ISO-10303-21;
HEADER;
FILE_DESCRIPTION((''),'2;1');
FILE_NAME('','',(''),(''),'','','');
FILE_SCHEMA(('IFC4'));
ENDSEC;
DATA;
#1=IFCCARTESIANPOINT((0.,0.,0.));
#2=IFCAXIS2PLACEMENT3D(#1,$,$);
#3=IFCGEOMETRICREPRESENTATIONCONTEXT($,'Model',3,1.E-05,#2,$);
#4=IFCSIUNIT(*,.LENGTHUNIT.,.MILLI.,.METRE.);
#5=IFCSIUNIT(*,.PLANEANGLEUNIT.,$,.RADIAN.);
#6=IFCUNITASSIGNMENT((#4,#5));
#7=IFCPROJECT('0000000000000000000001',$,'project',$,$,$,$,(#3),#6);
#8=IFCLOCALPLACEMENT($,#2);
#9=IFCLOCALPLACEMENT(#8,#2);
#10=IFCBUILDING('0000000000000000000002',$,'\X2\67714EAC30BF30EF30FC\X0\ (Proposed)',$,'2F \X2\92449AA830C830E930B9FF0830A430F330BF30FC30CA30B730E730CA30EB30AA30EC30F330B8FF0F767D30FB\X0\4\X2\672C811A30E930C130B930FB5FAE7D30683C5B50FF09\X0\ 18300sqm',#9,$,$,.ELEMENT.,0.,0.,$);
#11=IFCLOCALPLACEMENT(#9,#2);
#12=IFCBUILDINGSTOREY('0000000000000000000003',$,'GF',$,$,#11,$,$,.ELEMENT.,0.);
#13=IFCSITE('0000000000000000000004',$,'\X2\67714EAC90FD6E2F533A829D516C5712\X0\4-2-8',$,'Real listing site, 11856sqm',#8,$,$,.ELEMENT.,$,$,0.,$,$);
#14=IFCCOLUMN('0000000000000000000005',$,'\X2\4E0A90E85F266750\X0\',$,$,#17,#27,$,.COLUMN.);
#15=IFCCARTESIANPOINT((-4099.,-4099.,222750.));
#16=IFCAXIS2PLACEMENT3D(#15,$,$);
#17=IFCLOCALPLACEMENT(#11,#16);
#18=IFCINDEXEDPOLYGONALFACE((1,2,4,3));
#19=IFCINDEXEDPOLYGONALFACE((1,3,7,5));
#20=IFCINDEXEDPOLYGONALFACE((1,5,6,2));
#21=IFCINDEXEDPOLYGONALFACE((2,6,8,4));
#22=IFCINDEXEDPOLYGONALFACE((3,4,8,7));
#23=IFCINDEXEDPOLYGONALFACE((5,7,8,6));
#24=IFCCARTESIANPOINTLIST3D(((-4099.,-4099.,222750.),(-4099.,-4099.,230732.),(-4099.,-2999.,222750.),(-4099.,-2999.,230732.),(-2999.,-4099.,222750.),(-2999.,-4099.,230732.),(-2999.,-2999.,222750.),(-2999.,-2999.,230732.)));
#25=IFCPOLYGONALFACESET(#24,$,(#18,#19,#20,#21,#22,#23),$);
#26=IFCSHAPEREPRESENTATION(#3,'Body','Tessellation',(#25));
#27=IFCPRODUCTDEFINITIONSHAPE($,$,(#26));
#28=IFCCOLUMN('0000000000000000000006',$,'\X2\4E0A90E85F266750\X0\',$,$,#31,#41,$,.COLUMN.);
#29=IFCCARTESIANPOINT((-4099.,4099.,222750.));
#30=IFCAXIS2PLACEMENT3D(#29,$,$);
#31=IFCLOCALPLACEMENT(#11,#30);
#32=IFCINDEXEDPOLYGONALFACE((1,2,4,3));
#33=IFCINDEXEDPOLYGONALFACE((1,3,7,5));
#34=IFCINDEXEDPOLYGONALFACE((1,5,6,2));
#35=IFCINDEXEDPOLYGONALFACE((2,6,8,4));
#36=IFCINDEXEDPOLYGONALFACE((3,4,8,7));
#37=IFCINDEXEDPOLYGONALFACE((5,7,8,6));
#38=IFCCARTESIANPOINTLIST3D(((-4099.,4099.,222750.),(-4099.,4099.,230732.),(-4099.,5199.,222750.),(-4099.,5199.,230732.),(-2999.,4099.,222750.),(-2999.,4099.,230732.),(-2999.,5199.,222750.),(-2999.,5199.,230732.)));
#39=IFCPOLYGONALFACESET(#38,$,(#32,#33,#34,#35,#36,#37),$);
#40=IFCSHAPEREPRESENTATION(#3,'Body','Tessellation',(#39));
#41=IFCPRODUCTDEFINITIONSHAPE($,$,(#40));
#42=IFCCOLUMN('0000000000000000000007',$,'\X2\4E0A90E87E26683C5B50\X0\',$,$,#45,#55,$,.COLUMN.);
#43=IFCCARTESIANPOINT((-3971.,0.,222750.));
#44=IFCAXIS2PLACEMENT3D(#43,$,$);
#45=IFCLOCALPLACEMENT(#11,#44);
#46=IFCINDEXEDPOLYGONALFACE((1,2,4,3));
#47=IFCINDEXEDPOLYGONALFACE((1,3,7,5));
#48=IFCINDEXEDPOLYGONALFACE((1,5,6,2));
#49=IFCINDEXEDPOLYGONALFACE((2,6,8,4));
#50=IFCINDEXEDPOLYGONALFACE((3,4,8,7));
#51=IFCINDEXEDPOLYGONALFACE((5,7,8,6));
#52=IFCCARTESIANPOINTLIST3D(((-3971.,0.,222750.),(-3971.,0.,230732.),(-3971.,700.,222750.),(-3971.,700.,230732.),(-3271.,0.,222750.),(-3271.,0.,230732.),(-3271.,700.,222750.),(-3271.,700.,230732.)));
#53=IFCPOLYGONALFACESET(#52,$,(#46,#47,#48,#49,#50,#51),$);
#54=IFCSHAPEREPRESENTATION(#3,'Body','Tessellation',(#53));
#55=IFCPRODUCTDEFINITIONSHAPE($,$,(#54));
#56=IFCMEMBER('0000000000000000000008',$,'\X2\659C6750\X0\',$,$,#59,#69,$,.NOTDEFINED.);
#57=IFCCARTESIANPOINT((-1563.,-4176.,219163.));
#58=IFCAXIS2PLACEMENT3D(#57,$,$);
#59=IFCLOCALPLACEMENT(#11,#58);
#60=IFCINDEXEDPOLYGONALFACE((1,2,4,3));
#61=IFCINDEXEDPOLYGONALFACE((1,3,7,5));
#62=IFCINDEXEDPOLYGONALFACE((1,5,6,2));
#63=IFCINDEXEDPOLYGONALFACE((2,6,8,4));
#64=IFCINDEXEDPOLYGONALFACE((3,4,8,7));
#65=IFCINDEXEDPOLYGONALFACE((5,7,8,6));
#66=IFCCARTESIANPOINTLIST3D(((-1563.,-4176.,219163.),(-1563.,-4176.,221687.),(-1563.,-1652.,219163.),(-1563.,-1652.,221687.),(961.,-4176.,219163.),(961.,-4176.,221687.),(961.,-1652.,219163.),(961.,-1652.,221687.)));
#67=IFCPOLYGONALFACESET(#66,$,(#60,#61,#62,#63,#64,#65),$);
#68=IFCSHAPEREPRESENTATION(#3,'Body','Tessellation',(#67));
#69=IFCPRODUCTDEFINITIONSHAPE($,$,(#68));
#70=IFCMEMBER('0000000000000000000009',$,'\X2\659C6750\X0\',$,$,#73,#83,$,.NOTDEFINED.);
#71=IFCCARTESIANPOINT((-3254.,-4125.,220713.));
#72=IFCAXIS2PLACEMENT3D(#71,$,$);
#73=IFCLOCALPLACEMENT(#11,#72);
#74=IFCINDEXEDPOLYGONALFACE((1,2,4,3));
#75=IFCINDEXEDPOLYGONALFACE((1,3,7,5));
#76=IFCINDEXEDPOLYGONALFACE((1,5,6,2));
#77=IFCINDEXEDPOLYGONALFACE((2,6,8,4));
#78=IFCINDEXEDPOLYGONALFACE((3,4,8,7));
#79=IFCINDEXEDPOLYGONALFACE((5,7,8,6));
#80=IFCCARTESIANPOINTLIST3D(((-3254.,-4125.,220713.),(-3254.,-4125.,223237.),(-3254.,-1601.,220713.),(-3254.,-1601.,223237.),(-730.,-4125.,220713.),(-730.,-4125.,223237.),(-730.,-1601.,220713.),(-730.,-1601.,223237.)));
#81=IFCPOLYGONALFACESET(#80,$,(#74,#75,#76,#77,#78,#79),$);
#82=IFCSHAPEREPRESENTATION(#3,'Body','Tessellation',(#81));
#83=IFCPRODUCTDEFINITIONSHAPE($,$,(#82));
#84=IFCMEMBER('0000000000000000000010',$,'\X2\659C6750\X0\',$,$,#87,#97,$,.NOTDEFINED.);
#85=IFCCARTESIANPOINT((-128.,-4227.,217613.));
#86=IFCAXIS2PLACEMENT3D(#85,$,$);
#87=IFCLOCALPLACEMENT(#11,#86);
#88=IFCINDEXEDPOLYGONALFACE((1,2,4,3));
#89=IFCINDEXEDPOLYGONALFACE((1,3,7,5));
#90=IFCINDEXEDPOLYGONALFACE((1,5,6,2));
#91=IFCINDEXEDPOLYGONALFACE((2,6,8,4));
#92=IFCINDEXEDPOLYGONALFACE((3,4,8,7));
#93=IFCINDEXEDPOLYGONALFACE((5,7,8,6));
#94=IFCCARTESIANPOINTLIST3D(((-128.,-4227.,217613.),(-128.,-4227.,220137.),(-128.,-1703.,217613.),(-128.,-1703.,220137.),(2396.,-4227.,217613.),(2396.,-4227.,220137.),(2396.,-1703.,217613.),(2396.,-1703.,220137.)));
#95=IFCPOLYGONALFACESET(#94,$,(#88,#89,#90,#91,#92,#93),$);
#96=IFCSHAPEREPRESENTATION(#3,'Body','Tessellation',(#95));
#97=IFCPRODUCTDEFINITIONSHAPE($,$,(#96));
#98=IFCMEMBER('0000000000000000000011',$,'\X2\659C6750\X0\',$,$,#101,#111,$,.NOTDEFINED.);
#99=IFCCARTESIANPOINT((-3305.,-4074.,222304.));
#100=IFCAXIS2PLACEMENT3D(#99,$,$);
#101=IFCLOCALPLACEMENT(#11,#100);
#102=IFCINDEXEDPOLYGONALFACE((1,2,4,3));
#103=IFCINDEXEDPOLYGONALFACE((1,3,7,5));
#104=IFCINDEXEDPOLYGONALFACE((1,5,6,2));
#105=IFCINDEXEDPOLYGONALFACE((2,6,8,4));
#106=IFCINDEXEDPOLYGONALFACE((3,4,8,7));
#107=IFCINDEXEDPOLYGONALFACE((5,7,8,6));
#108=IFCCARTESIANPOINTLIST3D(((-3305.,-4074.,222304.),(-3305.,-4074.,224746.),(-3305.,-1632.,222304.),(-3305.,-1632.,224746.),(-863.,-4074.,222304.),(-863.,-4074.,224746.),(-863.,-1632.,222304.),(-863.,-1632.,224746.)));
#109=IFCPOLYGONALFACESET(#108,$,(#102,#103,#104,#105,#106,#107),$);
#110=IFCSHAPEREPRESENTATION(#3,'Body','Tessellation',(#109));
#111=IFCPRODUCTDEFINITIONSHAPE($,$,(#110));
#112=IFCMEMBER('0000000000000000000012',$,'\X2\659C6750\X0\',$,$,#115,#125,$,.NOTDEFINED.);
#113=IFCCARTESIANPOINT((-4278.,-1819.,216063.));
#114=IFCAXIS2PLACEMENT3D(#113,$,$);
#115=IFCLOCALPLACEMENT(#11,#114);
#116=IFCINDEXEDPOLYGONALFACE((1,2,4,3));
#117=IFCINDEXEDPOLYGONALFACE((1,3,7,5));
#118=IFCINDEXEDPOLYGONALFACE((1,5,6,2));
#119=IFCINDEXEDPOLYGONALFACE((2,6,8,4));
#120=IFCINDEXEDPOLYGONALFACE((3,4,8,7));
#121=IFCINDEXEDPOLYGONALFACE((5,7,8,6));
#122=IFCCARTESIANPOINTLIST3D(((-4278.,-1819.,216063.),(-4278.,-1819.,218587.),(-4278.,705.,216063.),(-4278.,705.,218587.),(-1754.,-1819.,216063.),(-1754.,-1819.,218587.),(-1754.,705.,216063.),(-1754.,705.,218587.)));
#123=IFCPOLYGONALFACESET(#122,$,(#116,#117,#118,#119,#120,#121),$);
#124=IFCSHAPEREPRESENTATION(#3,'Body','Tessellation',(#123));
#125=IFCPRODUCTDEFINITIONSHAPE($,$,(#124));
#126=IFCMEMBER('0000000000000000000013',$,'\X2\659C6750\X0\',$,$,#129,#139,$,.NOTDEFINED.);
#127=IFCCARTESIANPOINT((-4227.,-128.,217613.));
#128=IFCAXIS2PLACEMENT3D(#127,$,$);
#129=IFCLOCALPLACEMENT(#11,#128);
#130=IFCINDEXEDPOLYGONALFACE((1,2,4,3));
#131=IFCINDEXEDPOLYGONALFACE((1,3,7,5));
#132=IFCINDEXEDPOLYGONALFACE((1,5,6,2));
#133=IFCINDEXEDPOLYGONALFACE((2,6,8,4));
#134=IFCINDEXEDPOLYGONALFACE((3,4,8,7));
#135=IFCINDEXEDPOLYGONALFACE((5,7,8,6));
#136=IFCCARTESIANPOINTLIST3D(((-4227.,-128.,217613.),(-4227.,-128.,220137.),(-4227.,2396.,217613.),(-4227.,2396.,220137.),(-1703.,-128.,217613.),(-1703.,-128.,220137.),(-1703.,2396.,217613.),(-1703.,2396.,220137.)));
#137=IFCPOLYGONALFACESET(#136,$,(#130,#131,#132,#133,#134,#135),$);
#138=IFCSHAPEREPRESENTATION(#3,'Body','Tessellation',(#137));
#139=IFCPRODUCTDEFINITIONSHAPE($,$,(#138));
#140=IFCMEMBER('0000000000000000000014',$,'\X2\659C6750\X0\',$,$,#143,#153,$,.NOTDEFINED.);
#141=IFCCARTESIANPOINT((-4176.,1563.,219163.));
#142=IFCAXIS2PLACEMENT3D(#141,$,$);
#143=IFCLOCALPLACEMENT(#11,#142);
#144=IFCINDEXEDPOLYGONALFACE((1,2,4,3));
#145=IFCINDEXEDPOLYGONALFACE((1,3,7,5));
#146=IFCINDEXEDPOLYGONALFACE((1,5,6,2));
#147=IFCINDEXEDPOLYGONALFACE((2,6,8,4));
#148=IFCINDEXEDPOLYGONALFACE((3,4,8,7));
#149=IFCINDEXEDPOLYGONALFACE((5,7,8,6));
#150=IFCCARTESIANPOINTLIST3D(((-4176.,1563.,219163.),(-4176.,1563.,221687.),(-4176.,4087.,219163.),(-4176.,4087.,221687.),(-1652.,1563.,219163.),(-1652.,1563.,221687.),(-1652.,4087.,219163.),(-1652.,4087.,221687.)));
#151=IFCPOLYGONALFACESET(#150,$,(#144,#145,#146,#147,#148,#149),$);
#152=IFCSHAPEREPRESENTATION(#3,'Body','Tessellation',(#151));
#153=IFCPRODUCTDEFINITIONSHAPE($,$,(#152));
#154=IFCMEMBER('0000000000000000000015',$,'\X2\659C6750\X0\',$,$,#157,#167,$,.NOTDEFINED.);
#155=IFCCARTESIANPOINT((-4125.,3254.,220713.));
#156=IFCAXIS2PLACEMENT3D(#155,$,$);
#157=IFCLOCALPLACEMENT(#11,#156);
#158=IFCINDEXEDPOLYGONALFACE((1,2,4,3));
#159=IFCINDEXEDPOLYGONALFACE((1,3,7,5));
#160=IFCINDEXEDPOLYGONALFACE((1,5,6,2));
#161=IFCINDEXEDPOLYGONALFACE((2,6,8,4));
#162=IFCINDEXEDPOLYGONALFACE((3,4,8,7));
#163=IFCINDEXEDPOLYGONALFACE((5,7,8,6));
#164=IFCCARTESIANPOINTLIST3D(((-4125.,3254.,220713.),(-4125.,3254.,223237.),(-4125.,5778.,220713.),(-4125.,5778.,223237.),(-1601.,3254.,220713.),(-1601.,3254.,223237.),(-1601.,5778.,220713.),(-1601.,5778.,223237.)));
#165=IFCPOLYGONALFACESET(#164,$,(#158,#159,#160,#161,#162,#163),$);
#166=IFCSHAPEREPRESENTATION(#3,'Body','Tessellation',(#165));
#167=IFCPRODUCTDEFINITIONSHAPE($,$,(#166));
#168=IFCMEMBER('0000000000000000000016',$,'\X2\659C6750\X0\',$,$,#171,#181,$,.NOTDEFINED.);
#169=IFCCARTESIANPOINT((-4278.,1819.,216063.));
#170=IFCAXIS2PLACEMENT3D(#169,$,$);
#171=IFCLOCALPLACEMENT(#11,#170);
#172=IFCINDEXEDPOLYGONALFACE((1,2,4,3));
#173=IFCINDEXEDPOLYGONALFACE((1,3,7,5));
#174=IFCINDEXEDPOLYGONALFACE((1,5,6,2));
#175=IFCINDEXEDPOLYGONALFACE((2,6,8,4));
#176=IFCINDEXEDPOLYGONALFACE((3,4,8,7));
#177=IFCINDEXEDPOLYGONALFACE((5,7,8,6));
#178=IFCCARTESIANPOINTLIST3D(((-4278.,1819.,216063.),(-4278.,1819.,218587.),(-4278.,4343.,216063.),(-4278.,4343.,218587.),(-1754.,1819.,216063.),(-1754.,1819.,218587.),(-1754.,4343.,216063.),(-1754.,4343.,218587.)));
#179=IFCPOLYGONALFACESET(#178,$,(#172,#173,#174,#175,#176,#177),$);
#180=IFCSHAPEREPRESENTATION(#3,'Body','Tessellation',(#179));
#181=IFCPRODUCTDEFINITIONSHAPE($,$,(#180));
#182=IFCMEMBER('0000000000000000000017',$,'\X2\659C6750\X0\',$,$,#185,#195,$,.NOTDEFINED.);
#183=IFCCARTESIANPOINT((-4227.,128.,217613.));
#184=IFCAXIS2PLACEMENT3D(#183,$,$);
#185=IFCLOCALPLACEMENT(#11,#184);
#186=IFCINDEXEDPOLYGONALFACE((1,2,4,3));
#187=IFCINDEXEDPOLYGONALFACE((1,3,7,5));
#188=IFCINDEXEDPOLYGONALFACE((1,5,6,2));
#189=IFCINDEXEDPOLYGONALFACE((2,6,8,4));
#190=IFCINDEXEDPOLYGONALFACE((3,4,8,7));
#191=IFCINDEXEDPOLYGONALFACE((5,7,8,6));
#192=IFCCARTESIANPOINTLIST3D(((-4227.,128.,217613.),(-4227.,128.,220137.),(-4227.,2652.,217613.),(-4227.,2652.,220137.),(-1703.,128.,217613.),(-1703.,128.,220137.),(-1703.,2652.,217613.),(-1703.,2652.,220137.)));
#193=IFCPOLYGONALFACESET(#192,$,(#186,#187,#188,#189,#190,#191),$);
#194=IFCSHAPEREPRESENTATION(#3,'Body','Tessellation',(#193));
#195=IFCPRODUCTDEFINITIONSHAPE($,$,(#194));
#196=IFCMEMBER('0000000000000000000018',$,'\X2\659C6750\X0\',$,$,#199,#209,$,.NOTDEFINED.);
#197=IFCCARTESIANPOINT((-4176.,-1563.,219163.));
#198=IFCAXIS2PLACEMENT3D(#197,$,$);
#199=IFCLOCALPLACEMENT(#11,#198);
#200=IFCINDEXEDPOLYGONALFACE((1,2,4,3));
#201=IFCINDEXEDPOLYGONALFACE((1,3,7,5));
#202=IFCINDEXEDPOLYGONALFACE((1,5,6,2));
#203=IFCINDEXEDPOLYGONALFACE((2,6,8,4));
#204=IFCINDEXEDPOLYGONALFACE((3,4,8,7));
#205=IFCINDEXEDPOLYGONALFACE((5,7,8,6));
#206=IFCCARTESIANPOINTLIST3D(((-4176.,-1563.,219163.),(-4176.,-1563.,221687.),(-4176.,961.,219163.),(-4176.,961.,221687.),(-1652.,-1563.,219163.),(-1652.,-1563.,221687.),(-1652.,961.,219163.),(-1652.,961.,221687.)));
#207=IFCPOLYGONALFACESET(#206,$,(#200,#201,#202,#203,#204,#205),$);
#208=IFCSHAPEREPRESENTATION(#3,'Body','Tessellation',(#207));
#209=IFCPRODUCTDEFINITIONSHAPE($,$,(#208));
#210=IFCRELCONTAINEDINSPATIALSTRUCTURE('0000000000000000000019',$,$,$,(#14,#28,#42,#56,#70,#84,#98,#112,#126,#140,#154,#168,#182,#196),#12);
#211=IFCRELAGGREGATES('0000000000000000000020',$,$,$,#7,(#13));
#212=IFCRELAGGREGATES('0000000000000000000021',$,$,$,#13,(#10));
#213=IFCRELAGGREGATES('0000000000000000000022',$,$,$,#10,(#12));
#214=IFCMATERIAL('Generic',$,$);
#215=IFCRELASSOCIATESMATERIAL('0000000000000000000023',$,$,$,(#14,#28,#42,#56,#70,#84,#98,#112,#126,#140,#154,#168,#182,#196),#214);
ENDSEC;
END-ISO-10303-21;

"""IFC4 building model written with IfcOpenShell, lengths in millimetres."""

from ifc_helpers import new_model, si_unit, frame, frame_2d, origin, place, context, project, spatial, rectangle, extrude, material, element, save


model = new_model("IFC4")

# Units and contexts
model_context = context("Model", 3, precision=1e-05, world=origin())
ifc_project = project(units=[si_unit("LENGTHUNIT", "METRE", prefix="MILLI"), si_unit("PLANEANGLEUNIT", "RADIAN")], contexts=[model_context])

# Site, building, storey
site_placement = place(None, origin())
site = spatial("IfcSite", under=ifc_project, at=site_placement, Name="東京都港区芝公園4-2-8", ObjectType="Real listing site, 11856sqm", CompositionType="ELEMENT", RefElevation=0.0)
building_placement = place(site_placement, origin())
building = spatial("IfcBuilding", under=site, at=building_placement, Name="東京タワー (Proposed)", ObjectType="2F 鉄骨トラス（インターナショナルオレンジ／白・4本脚ラチス・微細格子） 18300sqm", CompositionType="ELEMENT", ElevationOfRefHeight=0.0, ElevationOfTerrain=0.0)
storey_placement = place(building_placement, origin())
storey = spatial("IfcBuildingStorey", under=building, at=storey_placement, Name="GF", CompositionType="ELEMENT", Elevation=0.0)

# Columns
ifc_material = material(Name="Generic")
column_1_placement = place(storey_placement, frame((-4099.0, -4099.0, 222750.0)))
element("IfcColumn", 1, at=column_1_placement, inside=storey, material=ifc_material, Name="上部弦材", PredefinedType="COLUMN", context=model_context, shape_type="SweptSolid", body=[
    extrude(rectangle(XDim=1100.0, YDim=1100.0, at=frame_2d((550.0, 550.0))), frame((-4099.0, -4099.0, 222750.0)), (0.0, 0.0, 1.0), 7982.0),
])
column_2_placement = place(storey_placement, frame((-4099.0, 4099.0, 222750.0)))
element("IfcColumn", 2, at=column_2_placement, inside=storey, material=ifc_material, Name="上部弦材", PredefinedType="COLUMN", context=model_context, shape_type="SweptSolid", body=[
    extrude(rectangle(XDim=1100.0, YDim=1100.0, at=frame_2d((550.0, 550.0))), frame((-4099.0, 4099.0, 222750.0)), (0.0, 0.0, 1.0), 7982.0),
])
column_3_placement = place(storey_placement, frame((-3971.0, 0.0, 222750.0)))
element("IfcColumn", 3, at=column_3_placement, inside=storey, material=ifc_material, Name="上部縦格子", PredefinedType="COLUMN", context=model_context, shape_type="SweptSolid", body=[
    extrude(rectangle(XDim=700.0, YDim=700.0, at=frame_2d((350.0, 350.0))), frame((-3971.0, 0.0, 222750.0)), (0.0, 0.0, 1.0), 7982.0),
])

# Members
member_1_placement = place(storey_placement, frame((-1563.0, -4176.0, 219163.0)))
element("IfcMember", 4, at=member_1_placement, inside=storey, material=ifc_material, Name="斜材", PredefinedType="NOTDEFINED", context=model_context, shape_type="SweptSolid", body=[
    extrude(rectangle(XDim=2524.0, YDim=2524.0, at=frame_2d((1262.0, 1262.0))), frame((-1563.0, -4176.0, 219163.0)), (0.0, 0.0, 1.0), 2524.0),
])
member_2_placement = place(storey_placement, frame((-3254.0, -4125.0, 220713.0)))
element("IfcMember", 5, at=member_2_placement, inside=storey, material=ifc_material, Name="斜材", PredefinedType="NOTDEFINED", context=model_context, shape_type="SweptSolid", body=[
    extrude(rectangle(XDim=2524.0, YDim=2524.0, at=frame_2d((1262.0, 1262.0))), frame((-3254.0, -4125.0, 220713.0)), (0.0, 0.0, 1.0), 2524.0),
])
member_3_placement = place(storey_placement, frame((-128.0, -4227.0, 217613.0)))
element("IfcMember", 6, at=member_3_placement, inside=storey, material=ifc_material, Name="斜材", PredefinedType="NOTDEFINED", context=model_context, shape_type="SweptSolid", body=[
    extrude(rectangle(XDim=2524.0, YDim=2524.0, at=frame_2d((1262.0, 1262.0))), frame((-128.0, -4227.0, 217613.0)), (0.0, 0.0, 1.0), 2524.0),
])
member_4_placement = place(storey_placement, frame((-3305.0, -4074.0, 222304.0)))
element("IfcMember", 7, at=member_4_placement, inside=storey, material=ifc_material, Name="斜材", PredefinedType="NOTDEFINED", context=model_context, shape_type="SweptSolid", body=[
    extrude(rectangle(XDim=2442.0, YDim=2442.0, at=frame_2d((1221.0, 1221.0))), frame((-3305.0, -4074.0, 222304.0)), (0.0, 0.0, 1.0), 2442.0),
])
member_5_placement = place(storey_placement, frame((-4278.0, -1819.0, 216063.0)))
element("IfcMember", 8, at=member_5_placement, inside=storey, material=ifc_material, Name="斜材", PredefinedType="NOTDEFINED", context=model_context, shape_type="SweptSolid", body=[
    extrude(rectangle(XDim=2524.0, YDim=2524.0, at=frame_2d((1262.0, 1262.0))), frame((-4278.0, -1819.0, 216063.0)), (0.0, 0.0, 1.0), 2524.0),
])
member_6_placement = place(storey_placement, frame((-4227.0, -128.0, 217613.0)))
element("IfcMember", 9, at=member_6_placement, inside=storey, material=ifc_material, Name="斜材", PredefinedType="NOTDEFINED", context=model_context, shape_type="SweptSolid", body=[
    extrude(rectangle(XDim=2524.0, YDim=2524.0, at=frame_2d((1262.0, 1262.0))), frame((-4227.0, -128.0, 217613.0)), (0.0, 0.0, 1.0), 2524.0),
])
member_7_placement = place(storey_placement, frame((-4176.0, 1563.0, 219163.0)))
element("IfcMember", 10, at=member_7_placement, inside=storey, material=ifc_material, Name="斜材", PredefinedType="NOTDEFINED", context=model_context, shape_type="SweptSolid", body=[
    extrude(rectangle(XDim=2524.0, YDim=2524.0, at=frame_2d((1262.0, 1262.0))), frame((-4176.0, 1563.0, 219163.0)), (0.0, 0.0, 1.0), 2524.0),
])
member_8_placement = place(storey_placement, frame((-4125.0, 3254.0, 220713.0)))
element("IfcMember", 11, at=member_8_placement, inside=storey, material=ifc_material, Name="斜材", PredefinedType="NOTDEFINED", context=model_context, shape_type="SweptSolid", body=[
    extrude(rectangle(XDim=2524.0, YDim=2524.0, at=frame_2d((1262.0, 1262.0))), frame((-4125.0, 3254.0, 220713.0)), (0.0, 0.0, 1.0), 2524.0),
])
member_9_placement = place(storey_placement, frame((-4278.0, 1819.0, 216063.0)))
element("IfcMember", 12, at=member_9_placement, inside=storey, material=ifc_material, Name="斜材", PredefinedType="NOTDEFINED", context=model_context, shape_type="SweptSolid", body=[
    extrude(rectangle(XDim=2524.0, YDim=2524.0, at=frame_2d((1262.0, 1262.0))), frame((-4278.0, 1819.0, 216063.0)), (0.0, 0.0, 1.0), 2524.0),
])
member_10_placement = place(storey_placement, frame((-4227.0, 128.0, 217613.0)))
element("IfcMember", 13, at=member_10_placement, inside=storey, material=ifc_material, Name="斜材", PredefinedType="NOTDEFINED", context=model_context, shape_type="SweptSolid", body=[
    extrude(rectangle(XDim=2524.0, YDim=2524.0, at=frame_2d((1262.0, 1262.0))), frame((-4227.0, 128.0, 217613.0)), (0.0, 0.0, 1.0), 2524.0),
])
member_11_placement = place(storey_placement, frame((-4176.0, -1563.0, 219163.0)))
element("IfcMember", 14, at=member_11_placement, inside=storey, material=ifc_material, Name="斜材", PredefinedType="NOTDEFINED", context=model_context, shape_type="SweptSolid", body=[
    extrude(rectangle(XDim=2524.0, YDim=2524.0, at=frame_2d((1262.0, 1262.0))), frame((-4176.0, -1563.0, 219163.0)), (0.0, 0.0, 1.0), 2524.0),
])

save(model, "model.ifc")
